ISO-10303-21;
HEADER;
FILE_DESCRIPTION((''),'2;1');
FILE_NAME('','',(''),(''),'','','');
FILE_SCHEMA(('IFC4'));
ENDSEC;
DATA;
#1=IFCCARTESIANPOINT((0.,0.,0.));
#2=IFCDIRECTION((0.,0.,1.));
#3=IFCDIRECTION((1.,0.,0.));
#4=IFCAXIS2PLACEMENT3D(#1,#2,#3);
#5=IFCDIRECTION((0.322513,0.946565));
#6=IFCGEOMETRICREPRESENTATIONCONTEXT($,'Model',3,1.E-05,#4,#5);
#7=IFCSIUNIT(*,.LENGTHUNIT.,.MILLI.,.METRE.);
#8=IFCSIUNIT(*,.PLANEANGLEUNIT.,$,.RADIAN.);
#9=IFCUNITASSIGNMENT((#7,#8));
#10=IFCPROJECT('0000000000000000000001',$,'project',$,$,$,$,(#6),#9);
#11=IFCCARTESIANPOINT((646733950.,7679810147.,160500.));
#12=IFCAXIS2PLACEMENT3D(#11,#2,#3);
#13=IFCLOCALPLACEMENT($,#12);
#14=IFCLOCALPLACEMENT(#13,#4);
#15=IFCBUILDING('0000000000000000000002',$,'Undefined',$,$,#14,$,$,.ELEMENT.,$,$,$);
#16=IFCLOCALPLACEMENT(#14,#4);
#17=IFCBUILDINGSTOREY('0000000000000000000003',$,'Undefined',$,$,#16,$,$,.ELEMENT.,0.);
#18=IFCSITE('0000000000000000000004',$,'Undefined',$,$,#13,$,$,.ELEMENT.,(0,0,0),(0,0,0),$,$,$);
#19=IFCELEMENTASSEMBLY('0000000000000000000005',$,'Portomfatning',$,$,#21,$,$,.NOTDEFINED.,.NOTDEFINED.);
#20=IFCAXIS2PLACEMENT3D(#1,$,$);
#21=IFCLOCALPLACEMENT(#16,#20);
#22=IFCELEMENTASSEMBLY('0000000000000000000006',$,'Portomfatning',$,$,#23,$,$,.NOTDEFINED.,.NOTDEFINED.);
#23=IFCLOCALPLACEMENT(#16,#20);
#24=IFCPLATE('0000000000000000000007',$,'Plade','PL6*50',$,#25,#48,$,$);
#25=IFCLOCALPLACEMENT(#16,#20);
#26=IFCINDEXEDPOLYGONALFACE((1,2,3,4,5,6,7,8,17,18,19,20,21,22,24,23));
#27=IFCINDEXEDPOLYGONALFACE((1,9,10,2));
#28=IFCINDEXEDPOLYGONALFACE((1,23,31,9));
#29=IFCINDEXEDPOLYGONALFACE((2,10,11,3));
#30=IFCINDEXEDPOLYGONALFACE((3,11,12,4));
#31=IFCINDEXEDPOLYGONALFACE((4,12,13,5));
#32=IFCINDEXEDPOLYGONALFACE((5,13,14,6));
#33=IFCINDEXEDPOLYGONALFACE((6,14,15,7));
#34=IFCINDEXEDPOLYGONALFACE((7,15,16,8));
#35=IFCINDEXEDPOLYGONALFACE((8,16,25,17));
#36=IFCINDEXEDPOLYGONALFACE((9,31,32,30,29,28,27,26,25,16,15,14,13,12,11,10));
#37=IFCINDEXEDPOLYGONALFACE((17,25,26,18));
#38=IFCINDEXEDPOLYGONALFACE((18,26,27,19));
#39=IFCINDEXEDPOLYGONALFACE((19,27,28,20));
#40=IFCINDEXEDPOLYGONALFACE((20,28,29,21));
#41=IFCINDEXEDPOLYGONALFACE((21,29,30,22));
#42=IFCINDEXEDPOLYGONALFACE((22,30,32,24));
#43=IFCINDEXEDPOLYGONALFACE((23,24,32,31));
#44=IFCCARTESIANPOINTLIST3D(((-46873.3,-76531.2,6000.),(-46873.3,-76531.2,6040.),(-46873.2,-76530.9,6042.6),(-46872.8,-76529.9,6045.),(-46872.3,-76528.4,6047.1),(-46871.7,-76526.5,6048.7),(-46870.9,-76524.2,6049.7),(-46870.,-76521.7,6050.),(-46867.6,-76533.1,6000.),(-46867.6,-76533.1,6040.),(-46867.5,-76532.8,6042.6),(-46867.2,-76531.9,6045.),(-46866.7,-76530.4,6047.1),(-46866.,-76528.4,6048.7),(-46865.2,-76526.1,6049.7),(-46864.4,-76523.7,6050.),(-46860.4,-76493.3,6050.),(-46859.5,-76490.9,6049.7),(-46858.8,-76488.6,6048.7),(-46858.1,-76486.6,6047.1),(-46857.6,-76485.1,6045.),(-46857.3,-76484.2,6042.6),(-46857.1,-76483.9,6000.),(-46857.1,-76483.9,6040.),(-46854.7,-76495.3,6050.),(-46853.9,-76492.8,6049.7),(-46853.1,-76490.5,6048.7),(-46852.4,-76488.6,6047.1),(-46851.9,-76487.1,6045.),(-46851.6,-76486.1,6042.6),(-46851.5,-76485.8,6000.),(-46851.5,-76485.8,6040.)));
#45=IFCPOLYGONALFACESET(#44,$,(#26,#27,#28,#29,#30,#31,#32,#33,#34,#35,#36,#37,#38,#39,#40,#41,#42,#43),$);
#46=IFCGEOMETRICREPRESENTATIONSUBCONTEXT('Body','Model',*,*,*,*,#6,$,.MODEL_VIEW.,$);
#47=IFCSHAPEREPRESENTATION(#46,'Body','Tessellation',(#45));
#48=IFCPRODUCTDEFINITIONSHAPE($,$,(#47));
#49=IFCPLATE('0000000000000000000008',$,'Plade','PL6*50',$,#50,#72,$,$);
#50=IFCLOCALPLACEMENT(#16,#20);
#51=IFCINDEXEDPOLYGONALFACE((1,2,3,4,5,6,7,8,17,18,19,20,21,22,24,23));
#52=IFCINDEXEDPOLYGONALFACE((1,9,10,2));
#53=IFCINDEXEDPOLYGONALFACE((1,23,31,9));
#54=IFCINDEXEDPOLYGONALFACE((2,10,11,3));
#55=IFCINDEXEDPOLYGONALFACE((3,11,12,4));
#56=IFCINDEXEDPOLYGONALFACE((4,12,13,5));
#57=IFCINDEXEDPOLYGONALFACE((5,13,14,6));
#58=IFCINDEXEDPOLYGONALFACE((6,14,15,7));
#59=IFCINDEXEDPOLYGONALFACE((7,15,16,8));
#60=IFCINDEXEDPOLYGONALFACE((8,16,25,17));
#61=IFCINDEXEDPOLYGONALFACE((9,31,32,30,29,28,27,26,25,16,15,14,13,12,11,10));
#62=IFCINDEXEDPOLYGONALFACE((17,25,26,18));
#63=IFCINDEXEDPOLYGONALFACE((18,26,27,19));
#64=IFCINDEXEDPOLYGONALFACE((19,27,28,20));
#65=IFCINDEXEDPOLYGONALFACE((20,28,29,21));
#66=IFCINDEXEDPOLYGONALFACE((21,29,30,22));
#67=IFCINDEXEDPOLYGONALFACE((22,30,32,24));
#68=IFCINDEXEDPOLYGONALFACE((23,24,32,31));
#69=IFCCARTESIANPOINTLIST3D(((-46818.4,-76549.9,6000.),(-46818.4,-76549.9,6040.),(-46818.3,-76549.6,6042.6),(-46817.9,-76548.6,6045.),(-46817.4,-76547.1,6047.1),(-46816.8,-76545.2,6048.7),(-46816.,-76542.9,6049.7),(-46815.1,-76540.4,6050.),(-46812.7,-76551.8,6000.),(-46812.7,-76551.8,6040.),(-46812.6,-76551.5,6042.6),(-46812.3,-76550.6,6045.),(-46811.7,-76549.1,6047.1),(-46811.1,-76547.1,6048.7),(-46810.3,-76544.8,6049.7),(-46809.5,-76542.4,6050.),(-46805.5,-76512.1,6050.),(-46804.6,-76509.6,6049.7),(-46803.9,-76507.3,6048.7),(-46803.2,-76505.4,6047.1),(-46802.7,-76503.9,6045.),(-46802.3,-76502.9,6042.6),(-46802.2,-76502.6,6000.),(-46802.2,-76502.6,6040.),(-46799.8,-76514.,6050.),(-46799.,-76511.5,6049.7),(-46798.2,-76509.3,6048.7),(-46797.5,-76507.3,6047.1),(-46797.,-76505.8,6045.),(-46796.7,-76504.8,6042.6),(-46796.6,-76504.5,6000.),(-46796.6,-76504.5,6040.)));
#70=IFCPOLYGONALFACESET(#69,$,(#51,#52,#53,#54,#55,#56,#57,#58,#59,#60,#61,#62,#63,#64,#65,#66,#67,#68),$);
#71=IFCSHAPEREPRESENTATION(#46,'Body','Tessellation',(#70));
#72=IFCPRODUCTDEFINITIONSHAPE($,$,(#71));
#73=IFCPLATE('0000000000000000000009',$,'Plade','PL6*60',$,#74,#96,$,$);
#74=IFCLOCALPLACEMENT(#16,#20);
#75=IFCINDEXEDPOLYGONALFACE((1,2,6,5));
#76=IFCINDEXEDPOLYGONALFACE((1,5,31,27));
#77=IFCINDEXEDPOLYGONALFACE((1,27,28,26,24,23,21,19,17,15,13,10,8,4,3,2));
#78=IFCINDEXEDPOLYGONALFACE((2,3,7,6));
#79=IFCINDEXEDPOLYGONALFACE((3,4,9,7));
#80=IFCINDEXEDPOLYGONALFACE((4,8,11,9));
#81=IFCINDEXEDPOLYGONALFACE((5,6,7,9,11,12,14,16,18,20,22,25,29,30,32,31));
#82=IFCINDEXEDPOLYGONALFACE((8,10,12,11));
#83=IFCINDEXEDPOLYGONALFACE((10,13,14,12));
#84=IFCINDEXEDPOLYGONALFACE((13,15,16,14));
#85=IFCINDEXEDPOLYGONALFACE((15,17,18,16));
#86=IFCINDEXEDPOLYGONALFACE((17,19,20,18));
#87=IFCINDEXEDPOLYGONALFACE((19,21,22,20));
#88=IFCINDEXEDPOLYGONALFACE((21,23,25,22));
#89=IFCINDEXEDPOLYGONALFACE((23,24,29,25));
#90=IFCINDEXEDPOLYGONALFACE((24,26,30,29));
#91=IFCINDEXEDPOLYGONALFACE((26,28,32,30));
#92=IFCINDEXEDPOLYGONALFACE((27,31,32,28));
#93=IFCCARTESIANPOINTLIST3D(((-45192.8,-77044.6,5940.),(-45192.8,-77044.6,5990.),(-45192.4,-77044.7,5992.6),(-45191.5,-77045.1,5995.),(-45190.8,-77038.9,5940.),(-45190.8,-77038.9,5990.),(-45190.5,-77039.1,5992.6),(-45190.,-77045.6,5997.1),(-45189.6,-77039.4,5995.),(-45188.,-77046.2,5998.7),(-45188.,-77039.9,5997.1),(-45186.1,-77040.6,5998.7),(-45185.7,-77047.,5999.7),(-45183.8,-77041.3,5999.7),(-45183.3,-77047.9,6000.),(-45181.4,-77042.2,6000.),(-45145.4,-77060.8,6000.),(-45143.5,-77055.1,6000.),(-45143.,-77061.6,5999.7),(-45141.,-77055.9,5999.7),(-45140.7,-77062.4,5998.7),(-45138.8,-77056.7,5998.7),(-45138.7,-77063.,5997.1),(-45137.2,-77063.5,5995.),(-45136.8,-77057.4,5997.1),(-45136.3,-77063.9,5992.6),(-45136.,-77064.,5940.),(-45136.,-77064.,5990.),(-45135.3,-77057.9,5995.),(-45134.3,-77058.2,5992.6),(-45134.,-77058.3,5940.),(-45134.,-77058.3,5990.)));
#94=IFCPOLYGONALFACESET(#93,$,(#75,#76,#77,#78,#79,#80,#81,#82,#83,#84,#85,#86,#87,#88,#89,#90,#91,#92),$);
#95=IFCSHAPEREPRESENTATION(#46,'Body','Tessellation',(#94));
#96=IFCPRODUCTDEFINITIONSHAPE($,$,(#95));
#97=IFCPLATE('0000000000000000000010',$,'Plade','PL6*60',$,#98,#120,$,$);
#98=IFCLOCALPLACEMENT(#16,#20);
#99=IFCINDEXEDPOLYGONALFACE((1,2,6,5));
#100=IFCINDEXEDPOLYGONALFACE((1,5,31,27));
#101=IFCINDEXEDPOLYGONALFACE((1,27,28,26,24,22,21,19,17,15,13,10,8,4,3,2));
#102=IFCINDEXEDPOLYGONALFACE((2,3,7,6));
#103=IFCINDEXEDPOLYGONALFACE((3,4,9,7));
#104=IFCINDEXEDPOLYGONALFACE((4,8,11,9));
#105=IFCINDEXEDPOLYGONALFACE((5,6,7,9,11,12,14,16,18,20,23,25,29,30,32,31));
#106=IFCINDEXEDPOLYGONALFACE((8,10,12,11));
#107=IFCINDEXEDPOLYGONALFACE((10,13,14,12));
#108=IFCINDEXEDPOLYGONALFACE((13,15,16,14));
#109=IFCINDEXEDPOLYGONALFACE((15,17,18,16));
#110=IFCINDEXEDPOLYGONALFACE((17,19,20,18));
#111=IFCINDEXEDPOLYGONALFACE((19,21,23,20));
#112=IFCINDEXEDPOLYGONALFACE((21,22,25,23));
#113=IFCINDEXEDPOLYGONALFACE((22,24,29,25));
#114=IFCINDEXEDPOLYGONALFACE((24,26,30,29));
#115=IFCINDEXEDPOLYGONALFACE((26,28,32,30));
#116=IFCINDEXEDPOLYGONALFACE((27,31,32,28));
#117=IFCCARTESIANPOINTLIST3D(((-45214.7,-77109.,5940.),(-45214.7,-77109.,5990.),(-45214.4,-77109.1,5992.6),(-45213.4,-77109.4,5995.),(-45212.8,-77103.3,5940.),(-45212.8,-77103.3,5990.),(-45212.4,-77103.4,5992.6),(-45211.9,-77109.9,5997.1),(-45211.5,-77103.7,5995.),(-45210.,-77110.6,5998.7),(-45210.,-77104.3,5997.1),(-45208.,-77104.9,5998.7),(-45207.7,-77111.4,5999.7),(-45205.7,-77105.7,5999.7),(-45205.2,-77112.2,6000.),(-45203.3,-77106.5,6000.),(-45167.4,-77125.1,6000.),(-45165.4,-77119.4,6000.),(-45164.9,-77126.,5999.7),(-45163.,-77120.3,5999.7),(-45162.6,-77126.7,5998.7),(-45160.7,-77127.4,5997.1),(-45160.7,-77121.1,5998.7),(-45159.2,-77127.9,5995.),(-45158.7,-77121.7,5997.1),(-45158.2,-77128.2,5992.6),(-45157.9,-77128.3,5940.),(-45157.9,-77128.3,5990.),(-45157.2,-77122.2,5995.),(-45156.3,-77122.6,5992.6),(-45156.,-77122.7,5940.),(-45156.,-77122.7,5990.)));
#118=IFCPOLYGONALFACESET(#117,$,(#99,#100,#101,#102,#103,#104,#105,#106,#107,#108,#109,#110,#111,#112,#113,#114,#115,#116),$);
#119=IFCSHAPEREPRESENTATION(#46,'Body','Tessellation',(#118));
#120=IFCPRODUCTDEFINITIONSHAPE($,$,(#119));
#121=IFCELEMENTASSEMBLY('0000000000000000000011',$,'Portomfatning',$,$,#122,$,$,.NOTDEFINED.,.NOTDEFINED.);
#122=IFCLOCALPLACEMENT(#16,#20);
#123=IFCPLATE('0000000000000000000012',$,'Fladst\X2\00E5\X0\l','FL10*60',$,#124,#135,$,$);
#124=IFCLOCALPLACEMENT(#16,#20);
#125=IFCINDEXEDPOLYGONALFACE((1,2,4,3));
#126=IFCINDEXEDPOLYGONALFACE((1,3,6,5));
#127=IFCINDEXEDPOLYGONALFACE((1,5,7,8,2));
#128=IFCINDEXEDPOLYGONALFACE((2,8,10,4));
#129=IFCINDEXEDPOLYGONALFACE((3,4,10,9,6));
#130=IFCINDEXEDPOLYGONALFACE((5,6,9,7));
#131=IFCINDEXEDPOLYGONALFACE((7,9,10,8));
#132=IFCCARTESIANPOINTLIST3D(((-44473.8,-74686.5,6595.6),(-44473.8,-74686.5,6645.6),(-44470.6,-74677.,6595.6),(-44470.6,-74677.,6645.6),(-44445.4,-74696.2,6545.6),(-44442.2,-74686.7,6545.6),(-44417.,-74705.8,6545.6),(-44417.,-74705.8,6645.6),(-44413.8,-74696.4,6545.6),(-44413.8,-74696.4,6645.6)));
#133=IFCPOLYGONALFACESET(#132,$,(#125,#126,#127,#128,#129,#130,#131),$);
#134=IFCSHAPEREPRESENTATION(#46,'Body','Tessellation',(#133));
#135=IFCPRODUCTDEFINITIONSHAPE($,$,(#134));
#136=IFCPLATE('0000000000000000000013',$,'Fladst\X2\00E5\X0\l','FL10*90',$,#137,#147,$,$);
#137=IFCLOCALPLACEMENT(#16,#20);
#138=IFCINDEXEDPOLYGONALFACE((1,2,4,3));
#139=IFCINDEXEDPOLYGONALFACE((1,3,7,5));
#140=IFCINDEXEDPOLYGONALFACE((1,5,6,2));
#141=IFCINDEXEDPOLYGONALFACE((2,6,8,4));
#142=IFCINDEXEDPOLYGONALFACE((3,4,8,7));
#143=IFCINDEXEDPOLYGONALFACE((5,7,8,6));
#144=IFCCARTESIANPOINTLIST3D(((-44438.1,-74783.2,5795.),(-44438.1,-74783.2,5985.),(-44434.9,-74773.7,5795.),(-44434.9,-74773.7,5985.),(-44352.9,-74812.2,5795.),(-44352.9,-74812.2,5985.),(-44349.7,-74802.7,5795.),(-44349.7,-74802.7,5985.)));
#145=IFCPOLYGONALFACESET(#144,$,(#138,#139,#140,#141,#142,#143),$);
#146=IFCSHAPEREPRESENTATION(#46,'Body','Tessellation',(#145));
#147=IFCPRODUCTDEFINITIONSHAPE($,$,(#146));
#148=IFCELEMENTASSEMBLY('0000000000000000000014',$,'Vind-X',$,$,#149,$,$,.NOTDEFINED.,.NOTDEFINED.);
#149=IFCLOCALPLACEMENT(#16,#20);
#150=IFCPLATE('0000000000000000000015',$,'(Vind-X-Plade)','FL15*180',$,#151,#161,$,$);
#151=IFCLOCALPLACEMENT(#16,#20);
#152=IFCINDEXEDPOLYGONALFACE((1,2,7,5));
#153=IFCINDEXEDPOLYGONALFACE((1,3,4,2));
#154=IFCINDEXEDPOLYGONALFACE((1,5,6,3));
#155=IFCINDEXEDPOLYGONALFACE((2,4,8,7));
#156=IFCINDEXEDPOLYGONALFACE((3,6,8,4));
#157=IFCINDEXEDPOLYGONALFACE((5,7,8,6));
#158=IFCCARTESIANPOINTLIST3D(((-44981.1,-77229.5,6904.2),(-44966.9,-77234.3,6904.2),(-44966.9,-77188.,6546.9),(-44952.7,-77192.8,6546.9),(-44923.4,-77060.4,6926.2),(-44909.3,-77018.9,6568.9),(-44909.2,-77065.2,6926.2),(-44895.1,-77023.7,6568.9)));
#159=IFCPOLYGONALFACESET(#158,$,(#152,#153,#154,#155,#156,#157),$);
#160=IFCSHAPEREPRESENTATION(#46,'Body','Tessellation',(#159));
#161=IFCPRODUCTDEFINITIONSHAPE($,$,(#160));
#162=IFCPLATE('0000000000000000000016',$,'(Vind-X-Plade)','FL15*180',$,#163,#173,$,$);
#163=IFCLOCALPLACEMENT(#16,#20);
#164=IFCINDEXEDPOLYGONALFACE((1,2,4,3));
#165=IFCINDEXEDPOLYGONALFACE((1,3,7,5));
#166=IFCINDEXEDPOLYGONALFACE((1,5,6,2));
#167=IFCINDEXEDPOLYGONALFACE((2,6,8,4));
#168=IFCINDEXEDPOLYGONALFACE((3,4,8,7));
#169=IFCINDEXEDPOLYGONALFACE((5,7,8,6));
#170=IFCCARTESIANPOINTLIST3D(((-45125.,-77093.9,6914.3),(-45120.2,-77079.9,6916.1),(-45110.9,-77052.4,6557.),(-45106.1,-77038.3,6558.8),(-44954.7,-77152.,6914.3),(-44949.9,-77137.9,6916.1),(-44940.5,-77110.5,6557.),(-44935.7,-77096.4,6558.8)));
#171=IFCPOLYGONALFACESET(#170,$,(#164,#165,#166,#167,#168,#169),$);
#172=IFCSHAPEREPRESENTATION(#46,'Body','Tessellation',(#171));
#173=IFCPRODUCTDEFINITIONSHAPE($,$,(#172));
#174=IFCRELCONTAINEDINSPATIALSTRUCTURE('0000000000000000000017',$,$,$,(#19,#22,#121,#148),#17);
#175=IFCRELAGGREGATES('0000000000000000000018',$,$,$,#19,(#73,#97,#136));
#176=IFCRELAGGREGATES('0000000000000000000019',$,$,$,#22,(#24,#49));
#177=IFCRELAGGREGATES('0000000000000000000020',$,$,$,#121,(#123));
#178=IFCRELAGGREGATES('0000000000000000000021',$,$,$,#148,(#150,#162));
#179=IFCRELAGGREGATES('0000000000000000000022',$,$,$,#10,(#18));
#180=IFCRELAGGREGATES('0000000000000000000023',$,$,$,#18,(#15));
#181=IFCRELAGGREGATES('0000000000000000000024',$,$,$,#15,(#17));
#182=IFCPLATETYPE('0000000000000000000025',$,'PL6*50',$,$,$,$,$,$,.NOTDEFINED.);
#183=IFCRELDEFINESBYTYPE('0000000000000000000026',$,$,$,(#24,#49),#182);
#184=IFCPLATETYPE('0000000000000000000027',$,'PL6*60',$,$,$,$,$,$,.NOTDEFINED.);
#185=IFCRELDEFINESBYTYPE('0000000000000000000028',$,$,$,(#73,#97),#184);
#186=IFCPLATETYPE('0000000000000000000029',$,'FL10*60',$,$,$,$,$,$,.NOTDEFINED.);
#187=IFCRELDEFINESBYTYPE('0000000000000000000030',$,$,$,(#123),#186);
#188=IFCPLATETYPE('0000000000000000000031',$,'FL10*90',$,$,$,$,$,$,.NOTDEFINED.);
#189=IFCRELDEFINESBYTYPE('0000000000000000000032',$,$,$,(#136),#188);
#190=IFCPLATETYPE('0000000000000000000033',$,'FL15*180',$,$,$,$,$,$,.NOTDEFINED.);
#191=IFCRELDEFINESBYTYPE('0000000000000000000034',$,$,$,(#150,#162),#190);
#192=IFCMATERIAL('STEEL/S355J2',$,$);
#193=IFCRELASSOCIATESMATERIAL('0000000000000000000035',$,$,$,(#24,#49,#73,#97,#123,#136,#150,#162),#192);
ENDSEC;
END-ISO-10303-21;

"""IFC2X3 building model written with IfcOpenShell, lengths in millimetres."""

from ifc_helpers import new_model, si_unit, direction, frame, frame_2d, origin_with_axes, place, context, subcontext, project, spatial, polyline, circle_curve, parameter, trimmed, segment, composite_curve, outline, extrude, material, type_object, element, aggregate, save


model = new_model("IFC2X3")

# Units and contexts
model_context = context("Model", 3, precision=1e-05, world=origin_with_axes(), true_north=direction((0.322513, 0.946565)))
body_context = subcontext(model_context, "Body", "Model", "MODEL_VIEW")
ifc_project = project(units=[si_unit("LENGTHUNIT", "METRE", prefix="MILLI"), si_unit("PLANEANGLEUNIT", "RADIAN")], contexts=[model_context])

# Site, building, storey
site_placement = place(None, frame((646733950.0, 7679810147.0, 160500.0), z_axis=(0.0, 0.0, 1.0), x_axis=(1.0, 0.0, 0.0)))
site = spatial("IfcSite", under=ifc_project, at=site_placement, Name="Undefined", CompositionType="ELEMENT", RefLatitude=(0, 0, 0), RefLongitude=(0, 0, 0))
building_placement = place(site_placement, origin_with_axes())
building = spatial("IfcBuilding", under=site, at=building_placement, Name="Undefined", CompositionType="ELEMENT")
storey_placement = place(building_placement, origin_with_axes())
storey = spatial("IfcBuildingStorey", under=building, at=storey_placement, Name="Undefined", CompositionType="ELEMENT", Elevation=0.0)

# Element assembly
assembly_1_placement = place(storey_placement, origin_with_axes())
assembly_1 = element("IfcElementAssembly", 1, at=assembly_1_placement, inside=storey, Name="Portomfatning", AssemblyPlace="NOTDEFINED", PredefinedType="NOTDEFINED")

# Element assembly
assembly_2_placement = place(storey_placement, origin_with_axes())
assembly_2 = element("IfcElementAssembly", 2, at=assembly_2_placement, inside=storey, Name="Portomfatning", AssemblyPlace="NOTDEFINED", PredefinedType="NOTDEFINED")

# Shared definitions
ifc_material_1 = material(Name="STEEL/S355J2")

# Plates
plate_type_1 = type_object("IfcPlateType", Name="PL6*50", PredefinedType="NOTDEFINED")
plate_1_placement = place(assembly_2_placement, frame((-46870.4, -76532.2, 6050.0), z_axis=(0.946565, -0.322513, 0.0), x_axis=(0.0, 0.0, -1.0)))
plate_1 = element("IfcPlate", 3, at=plate_1_placement, type_object=plate_type_1, material=ifc_material_1, Name="Plade", Description="PL6*50", context=body_context, shape_type="SweptSolid", body=[
    extrude(outline(composite_curve([segment(trimmed(circle_curve(frame_2d((10.0, 10.0), x_axis=(-1.0, -0.000002)), 10.0), [parameter(0.0)], [parameter(1.570794)], True, "PARAMETER"), True, "CONTINUOUS"), segment(polyline([(10.0, 0.0), (50.0, 0.0), (50.0, 50.0), (10.0, 50.0)]), True, "CONTINUOUS"), segment(trimmed(circle_curve(frame_2d((10.0, 40.0), x_axis=(0.0, 1.0)), 10.0), [parameter(0.0)], [parameter(1.570798)], True, "PARAMETER"), True, "CONTINUOUS"), segment(polyline([(0.0, 40.0), (0.0, 10.0)]), True, "CONTINUOUS")], self_intersect=True)), frame((0.0, 0.0, -3.0), z_axis=(0.0, 0.0, 1.0), x_axis=(1.0, 0.0, 0.0)), (0.0, 0.0, 1.0), 6.0),
])
plate_2_placement = place(assembly_2_placement, frame((-46815.5, -76550.9, 6050.0), z_axis=(0.946565, -0.322513, 0.0), x_axis=(0.0, 0.0, -1.0)))
plate_2 = element("IfcPlate", 4, at=plate_2_placement, type_object=plate_type_1, material=ifc_material_1, Name="Plade", Description="PL6*50", context=body_context, shape_type="SweptSolid", body=[
    extrude(outline(composite_curve([segment(trimmed(circle_curve(frame_2d((10.0, 10.0), x_axis=(-1.0, -0.000002)), 10.0), [parameter(0.0)], [parameter(1.570794)], True, "PARAMETER"), True, "CONTINUOUS"), segment(polyline([(10.0, 0.0), (50.0, 0.0), (50.0, 50.0), (10.0, 50.0)]), True, "CONTINUOUS"), segment(trimmed(circle_curve(frame_2d((10.0, 40.0), x_axis=(0.0, 1.0)), 10.0), [parameter(0.0)], [parameter(1.570798)], True, "PARAMETER"), True, "CONTINUOUS"), segment(polyline([(0.0, 40.0), (0.0, 10.0)]), True, "CONTINUOUS")], self_intersect=True)), frame((0.0, 0.0, -3.0), z_axis=(0.0, 0.0, 1.0), x_axis=(1.0, 0.0, 0.0)), (0.0, 0.0, 1.0), 6.0),
])
plate_type_2 = type_object("IfcPlateType", Name="PL6*60", PredefinedType="NOTDEFINED")
plate_3_placement = place(assembly_1_placement, frame((-45191.8, -77041.8, 5940.0), z_axis=(-0.322513, -0.946565, 0.0), x_axis=(0.946565, -0.322513, 0.0)))
plate_3 = element("IfcPlate", 5, at=plate_3_placement, type_object=plate_type_2, material=ifc_material_1, Name="Plade", Description="PL6*60", context=body_context, shape_type="SweptSolid", body=[
    extrude(outline(composite_curve([segment(polyline([(0.0, 0.0), (60.0, 0.0), (60.0, 50.0)]), True, "CONTINUOUS"), segment(trimmed(circle_curve(frame_2d((50.0, 50.0), x_axis=(1.0, 0.0)), 10.0), [parameter(0.0)], [parameter(1.570796)], True, "PARAMETER"), True, "CONTINUOUS"), segment(polyline([(50.0, 60.0), (10.0, 60.0)]), True, "CONTINUOUS"), segment(trimmed(circle_curve(frame_2d((10.0, 50.0), x_axis=(0.0, 1.0)), 10.0), [parameter(0.0)], [parameter(1.570796)], True, "PARAMETER"), True, "CONTINUOUS"), segment(polyline([(0.0, 50.0), (0.0, 0.0)]), True, "CONTINUOUS")], self_intersect=True)), frame((0.0, 0.0, -3.0), z_axis=(0.0, 0.0, 1.0), x_axis=(1.0, 0.0, 0.0)), (0.0, 0.0, 1.0), 6.0),
])
plate_4_placement = place(assembly_1_placement, frame((-45213.7, -77106.2, 5940.0), z_axis=(-0.322513, -0.946565, 0.0), x_axis=(0.946565, -0.322513, 0.0)))
plate_4 = element("IfcPlate", 6, at=plate_4_placement, type_object=plate_type_2, material=ifc_material_1, Name="Plade", Description="PL6*60", context=body_context, shape_type="SweptSolid", body=[
    extrude(outline(composite_curve([segment(polyline([(0.0, 0.0), (60.0, 0.0), (60.0, 50.0)]), True, "CONTINUOUS"), segment(trimmed(circle_curve(frame_2d((50.0, 50.0), x_axis=(1.0, 0.0)), 10.0), [parameter(0.0)], [parameter(1.570796)], True, "PARAMETER"), True, "CONTINUOUS"), segment(polyline([(50.0, 60.0), (10.0, 60.0)]), True, "CONTINUOUS"), segment(trimmed(circle_curve(frame_2d((10.0, 50.0), x_axis=(0.0, 1.0)), 10.0), [parameter(0.0)], [parameter(1.570796)], True, "PARAMETER"), True, "CONTINUOUS"), segment(polyline([(0.0, 50.0), (0.0, 0.0)]), True, "CONTINUOUS")], self_intersect=True)), frame((0.0, 0.0, -3.0), z_axis=(0.0, 0.0, 1.0), x_axis=(1.0, 0.0, 0.0)), (0.0, 0.0, 1.0), 6.0),
])

# Element assembly, plate
assembly_3_placement = place(storey_placement, origin_with_axes())
assembly_3 = element("IfcElementAssembly", 7, at=assembly_3_placement, inside=storey, Name="Portomfatning", AssemblyPlace="NOTDEFINED", PredefinedType="NOTDEFINED")
plate_type_3 = type_object("IfcPlateType", Name="FL10*60", PredefinedType="NOTDEFINED")
plate_5_placement = place(assembly_3_placement, frame((-44415.4, -74701.1, 6645.6), z_axis=(0.322513, 0.946565, 0.0), x_axis=(0.0, 0.0, -1.0)))
plate_5 = element("IfcPlate", 8, at=plate_5_placement, type_object=plate_type_3, material=ifc_material_1, Name="Fladstål", Description="FL10*60", context=body_context, shape_type="SweptSolid", body=[
    extrude(outline(polyline([(0.0, 0.0), (100.0, 0.0), (100.0, 30.0), (50.0, 60.0), (0.0, 60.0), (0.0, 0.0)])), frame((0.0, 0.0, -5.0), z_axis=(0.0, 0.0, 1.0), x_axis=(1.0, 0.0, 0.0)), (0.0, 0.0, 1.0), 10.0),
])

# Plate
plate_type_4 = type_object("IfcPlateType", Name="FL10*90", PredefinedType="NOTDEFINED")
plate_6_placement = place(assembly_1_placement, frame((-44393.9, -74793.0, 5795.0), z_axis=(-0.322513, -0.946565, 0.0), x_axis=(0.0, 0.0, 1.0)))
plate_6 = element("IfcPlate", 9, at=plate_6_placement, type_object=plate_type_4, material=ifc_material_1, Name="Fladstål", Description="FL10*90", context=body_context, shape_type="SweptSolid", body=[
    extrude(outline(polyline([(0.0, -45.0), (0.0, 45.0), (190.0, 45.0), (190.0, -45.0), (0.0, -45.0)])), frame((0.0, 0.0, -5.0), z_axis=(0.0, 0.0, 1.0), x_axis=(1.0, 0.0, 0.0)), (0.0, 0.0, 1.0), 10.0),
])

# Element assembly, plates
assembly_4_placement = place(storey_placement, origin_with_axes())
assembly_4 = element("IfcElementAssembly", 10, at=assembly_4_placement, inside=storey, Name="Vind-X", AssemblyPlace="NOTDEFINED", PredefinedType="NOTDEFINED")
plate_type_5 = type_object("IfcPlateType", Name="FL15*180", PredefinedType="NOTDEFINED")
plate_7_placement = place(assembly_4_placement, frame((-44974.0, -77231.9, 6904.2), z_axis=(-0.946565, 0.322513, 0.0), x_axis=(0.320109, 0.93951, 0.121869)))
plate_7 = element("IfcPlate", 11, at=plate_7_placement, type_object=plate_type_5, material=ifc_material_1, Name="(Vind-X-Plade)", Description="FL15*180", context=body_context, shape_type="SweptSolid", body=[
    extrude(outline(polyline([(0.0, 0.0), (180.0, 0.0), (180.0, 360.0), (0.0, 360.0), (0.0, 0.0)])), frame((0.0, 0.0, -7.5), z_axis=(0.0, 0.0, 1.0), x_axis=(1.0, 0.0, 0.0)), (0.0, 0.0, 1.0), 15.0),
])
plate_8_placement = place(assembly_4_placement, frame((-45108.5, -77045.4, 6557.9), z_axis=(0.320109, 0.93951, 0.121869), x_axis=(-0.039304, -0.115357, 0.992546)))
plate_8 = element("IfcPlate", 12, at=plate_8_placement, type_object=plate_type_5, material=ifc_material_1, Name="(Vind-X-Plade)", Description="FL15*180", context=body_context, shape_type="SweptSolid", body=[
    extrude(outline(polyline([(0.0, 0.0), (360.0, 0.0), (360.0, 180.0), (0.0, 180.0), (0.0, 0.0)])), frame((0.0, 0.0, -7.5), z_axis=(0.0, 0.0, 1.0), x_axis=(1.0, 0.0, 0.0)), (0.0, 0.0, 1.0), 15.0),
])

aggregate(assembly_1, [plate_3, plate_4, plate_6])

aggregate(assembly_2, [plate_1, plate_2])
aggregate(assembly_3, [plate_5])
aggregate(assembly_4, [plate_7, plate_8])

save(model, "model.ifc")
